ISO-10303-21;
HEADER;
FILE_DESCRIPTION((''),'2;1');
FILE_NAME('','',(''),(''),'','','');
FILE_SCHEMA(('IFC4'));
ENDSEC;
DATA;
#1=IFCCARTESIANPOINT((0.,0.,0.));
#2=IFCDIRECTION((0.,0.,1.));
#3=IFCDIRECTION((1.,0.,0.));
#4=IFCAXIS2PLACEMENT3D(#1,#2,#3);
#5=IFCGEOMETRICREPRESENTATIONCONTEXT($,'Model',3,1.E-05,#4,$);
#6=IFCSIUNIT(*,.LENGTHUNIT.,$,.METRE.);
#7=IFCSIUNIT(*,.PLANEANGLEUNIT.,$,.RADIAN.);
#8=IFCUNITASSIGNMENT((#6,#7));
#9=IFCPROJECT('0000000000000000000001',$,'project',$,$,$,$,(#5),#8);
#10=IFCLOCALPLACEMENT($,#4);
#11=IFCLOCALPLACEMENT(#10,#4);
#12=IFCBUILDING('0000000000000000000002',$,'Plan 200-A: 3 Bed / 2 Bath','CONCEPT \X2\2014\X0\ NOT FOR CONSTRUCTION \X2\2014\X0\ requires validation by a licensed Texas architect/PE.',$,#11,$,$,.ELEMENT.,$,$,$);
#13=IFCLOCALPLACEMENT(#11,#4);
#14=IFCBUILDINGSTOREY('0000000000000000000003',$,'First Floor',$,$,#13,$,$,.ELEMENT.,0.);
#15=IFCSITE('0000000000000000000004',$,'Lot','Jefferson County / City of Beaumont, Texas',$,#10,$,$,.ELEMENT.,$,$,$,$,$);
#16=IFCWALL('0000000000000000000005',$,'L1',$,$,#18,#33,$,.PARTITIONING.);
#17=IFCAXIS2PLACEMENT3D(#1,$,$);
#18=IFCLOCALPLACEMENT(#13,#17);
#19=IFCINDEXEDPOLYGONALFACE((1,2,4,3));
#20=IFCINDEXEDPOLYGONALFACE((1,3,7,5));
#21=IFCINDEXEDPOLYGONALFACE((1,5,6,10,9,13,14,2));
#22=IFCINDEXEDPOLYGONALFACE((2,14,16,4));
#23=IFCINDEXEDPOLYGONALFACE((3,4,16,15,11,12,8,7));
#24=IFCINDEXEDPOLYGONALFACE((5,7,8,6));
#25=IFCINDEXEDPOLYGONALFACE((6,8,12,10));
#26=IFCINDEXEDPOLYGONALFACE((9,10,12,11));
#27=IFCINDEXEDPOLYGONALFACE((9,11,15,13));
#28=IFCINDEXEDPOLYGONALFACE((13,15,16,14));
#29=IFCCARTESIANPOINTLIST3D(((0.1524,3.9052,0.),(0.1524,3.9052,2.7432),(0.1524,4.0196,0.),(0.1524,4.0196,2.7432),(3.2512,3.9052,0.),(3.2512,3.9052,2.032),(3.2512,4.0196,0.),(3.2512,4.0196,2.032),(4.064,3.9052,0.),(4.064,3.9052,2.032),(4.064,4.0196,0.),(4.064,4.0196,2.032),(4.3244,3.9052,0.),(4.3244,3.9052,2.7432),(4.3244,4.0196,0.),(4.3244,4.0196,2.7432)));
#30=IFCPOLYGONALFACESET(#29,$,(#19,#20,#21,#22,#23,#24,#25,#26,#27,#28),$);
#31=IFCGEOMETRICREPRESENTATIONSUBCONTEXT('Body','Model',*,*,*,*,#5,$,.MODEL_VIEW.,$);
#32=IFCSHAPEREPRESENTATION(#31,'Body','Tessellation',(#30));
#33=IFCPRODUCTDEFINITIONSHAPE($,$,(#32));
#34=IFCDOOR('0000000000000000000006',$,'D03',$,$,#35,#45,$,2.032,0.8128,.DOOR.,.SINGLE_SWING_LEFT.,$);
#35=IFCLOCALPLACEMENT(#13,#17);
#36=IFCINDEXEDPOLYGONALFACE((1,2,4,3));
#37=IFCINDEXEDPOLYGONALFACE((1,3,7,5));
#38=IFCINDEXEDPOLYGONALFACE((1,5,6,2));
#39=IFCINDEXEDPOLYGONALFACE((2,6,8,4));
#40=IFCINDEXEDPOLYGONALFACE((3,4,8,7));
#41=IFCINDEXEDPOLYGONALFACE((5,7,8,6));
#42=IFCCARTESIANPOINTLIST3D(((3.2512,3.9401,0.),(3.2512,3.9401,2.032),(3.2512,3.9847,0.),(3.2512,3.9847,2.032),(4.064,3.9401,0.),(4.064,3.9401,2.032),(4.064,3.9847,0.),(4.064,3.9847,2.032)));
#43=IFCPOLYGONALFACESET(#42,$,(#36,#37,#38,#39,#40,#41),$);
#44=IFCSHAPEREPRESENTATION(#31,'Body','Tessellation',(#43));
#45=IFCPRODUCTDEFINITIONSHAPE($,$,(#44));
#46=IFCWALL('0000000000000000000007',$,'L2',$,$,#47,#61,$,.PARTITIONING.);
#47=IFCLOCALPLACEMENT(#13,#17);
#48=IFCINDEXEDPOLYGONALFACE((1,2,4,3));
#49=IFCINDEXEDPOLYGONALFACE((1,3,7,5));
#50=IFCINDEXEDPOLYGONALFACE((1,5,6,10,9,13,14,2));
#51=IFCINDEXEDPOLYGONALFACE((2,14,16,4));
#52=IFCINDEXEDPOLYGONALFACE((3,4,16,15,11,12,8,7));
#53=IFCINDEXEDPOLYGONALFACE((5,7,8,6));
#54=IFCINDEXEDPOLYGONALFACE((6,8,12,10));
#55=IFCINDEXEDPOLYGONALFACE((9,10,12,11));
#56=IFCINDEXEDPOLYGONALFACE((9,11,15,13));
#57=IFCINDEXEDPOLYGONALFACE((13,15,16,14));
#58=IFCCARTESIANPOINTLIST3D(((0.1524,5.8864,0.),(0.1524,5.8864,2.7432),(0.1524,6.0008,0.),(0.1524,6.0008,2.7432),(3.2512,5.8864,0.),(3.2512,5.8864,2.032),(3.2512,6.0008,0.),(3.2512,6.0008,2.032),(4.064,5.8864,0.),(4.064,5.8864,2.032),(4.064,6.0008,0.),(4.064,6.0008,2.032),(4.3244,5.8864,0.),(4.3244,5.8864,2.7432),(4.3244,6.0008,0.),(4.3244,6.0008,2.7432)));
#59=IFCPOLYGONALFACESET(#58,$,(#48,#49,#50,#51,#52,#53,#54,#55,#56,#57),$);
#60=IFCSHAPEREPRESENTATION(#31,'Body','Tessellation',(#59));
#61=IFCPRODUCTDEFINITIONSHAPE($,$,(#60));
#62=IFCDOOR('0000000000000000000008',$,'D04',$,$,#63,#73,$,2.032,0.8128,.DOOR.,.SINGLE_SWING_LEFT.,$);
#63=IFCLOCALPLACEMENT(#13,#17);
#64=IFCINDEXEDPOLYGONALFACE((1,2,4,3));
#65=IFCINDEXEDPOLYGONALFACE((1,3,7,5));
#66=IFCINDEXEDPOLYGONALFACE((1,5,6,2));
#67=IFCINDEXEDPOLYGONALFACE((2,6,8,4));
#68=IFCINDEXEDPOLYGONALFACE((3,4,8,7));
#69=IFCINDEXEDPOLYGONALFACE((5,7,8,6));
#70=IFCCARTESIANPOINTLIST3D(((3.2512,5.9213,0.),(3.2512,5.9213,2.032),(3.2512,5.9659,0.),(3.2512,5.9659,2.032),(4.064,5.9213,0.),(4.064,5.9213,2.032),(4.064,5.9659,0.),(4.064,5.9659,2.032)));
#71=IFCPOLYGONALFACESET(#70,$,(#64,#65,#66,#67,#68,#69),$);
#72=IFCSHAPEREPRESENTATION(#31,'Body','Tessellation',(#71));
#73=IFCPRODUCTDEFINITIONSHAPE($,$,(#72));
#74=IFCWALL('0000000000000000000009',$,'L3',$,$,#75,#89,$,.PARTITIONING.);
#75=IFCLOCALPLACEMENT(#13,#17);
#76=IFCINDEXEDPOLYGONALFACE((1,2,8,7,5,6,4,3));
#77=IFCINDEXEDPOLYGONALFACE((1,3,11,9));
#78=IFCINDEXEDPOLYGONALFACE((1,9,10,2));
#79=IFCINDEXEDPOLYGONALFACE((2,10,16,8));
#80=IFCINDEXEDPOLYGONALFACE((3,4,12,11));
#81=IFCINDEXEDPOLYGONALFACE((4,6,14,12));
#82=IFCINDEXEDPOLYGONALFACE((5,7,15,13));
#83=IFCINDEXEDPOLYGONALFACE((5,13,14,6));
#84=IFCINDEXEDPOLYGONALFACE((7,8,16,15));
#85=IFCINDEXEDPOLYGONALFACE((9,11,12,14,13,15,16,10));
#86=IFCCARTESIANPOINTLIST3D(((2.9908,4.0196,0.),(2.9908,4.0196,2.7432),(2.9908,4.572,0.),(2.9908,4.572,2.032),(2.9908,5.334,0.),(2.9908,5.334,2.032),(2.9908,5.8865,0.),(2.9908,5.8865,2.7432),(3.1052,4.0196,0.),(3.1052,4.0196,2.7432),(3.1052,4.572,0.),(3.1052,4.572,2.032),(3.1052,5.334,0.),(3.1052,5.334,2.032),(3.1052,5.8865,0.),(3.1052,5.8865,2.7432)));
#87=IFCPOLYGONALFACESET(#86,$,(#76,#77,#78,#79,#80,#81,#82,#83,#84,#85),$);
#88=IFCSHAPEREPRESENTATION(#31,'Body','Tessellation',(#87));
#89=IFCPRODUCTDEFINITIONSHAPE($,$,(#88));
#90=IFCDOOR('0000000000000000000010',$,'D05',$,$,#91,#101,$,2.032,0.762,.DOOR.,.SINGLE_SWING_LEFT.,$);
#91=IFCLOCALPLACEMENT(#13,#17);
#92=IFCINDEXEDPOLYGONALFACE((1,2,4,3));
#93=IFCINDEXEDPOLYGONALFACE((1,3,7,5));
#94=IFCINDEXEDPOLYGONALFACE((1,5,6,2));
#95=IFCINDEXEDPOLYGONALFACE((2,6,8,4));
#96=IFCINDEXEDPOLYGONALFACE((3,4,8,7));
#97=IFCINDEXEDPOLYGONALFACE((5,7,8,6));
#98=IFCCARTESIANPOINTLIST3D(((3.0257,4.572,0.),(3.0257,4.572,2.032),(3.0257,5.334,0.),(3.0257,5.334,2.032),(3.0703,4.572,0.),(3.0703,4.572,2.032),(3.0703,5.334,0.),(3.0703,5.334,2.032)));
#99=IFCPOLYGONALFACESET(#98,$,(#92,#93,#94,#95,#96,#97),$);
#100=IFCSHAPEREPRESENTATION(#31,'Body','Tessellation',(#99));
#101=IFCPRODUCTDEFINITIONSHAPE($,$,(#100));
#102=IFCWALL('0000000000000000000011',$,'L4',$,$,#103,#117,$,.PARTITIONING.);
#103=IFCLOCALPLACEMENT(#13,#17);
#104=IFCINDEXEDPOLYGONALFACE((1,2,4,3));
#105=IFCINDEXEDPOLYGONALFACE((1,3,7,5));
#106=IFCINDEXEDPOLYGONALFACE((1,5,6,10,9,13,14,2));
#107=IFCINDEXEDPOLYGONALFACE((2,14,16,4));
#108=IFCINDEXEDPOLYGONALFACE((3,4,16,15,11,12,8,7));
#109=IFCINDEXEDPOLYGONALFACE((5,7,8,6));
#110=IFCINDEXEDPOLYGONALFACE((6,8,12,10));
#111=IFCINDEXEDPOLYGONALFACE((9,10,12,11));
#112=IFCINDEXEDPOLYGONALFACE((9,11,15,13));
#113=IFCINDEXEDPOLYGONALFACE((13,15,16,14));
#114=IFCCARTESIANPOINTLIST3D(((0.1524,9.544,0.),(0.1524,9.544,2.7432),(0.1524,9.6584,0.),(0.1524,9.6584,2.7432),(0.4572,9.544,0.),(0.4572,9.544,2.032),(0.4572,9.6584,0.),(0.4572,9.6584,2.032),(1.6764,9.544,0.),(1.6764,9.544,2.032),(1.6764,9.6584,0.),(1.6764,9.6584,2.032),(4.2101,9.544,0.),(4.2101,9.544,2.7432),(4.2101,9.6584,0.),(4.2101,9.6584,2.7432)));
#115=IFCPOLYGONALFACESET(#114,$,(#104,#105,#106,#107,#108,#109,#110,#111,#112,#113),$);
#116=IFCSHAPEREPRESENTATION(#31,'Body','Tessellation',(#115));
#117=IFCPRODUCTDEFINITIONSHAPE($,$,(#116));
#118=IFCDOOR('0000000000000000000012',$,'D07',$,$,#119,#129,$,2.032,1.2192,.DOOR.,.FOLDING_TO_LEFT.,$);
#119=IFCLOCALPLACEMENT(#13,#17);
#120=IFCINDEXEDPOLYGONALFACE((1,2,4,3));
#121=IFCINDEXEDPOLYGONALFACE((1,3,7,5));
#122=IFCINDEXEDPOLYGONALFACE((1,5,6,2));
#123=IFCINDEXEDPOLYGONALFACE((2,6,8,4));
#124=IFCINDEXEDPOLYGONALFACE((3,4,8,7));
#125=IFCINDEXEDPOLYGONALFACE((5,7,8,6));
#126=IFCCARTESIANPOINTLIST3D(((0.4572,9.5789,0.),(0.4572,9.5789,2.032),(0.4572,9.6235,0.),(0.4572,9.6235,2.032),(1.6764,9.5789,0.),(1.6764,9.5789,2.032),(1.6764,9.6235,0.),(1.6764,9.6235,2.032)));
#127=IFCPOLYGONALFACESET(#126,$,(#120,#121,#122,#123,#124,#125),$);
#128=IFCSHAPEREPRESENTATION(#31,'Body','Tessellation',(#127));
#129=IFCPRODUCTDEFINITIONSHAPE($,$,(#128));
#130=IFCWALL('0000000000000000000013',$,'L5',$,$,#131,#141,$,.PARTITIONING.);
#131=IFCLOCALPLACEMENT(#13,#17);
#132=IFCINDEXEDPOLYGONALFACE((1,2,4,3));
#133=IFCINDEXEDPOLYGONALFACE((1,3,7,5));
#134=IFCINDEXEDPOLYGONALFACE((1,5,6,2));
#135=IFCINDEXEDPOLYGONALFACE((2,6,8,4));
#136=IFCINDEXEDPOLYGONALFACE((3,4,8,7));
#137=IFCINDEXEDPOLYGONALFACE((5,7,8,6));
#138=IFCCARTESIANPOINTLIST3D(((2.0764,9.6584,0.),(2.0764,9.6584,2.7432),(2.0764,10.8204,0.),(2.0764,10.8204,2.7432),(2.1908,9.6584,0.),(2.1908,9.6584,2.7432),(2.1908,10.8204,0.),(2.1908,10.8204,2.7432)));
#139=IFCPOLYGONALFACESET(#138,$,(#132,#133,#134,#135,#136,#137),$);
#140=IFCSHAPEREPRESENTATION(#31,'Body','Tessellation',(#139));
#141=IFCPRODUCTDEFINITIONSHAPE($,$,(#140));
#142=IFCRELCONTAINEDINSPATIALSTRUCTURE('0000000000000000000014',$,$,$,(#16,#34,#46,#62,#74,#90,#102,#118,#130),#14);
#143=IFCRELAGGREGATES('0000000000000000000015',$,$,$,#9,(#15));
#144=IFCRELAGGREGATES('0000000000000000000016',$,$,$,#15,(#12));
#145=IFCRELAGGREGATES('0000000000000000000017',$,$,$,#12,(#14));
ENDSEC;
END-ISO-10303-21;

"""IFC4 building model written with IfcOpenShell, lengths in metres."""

from ifc_helpers import new_model, si_unit, frame, frame_2d, origin_with_axes, place, context, subcontext, project, spatial, rectangle, extrude, element, fill, save


model = new_model("IFC4")

# Units and contexts
model_context = context("Model", 3, precision=1e-05, world=origin_with_axes())
body_context = subcontext(model_context, "Body", "Model", "MODEL_VIEW")
ifc_project = project(units=[si_unit("LENGTHUNIT", "METRE"), si_unit("PLANEANGLEUNIT", "RADIAN")], contexts=[model_context])

# Site, building, storey
site_placement = place(None, origin_with_axes())
site = spatial("IfcSite", under=ifc_project, at=site_placement, Name="Lot", Description="Jefferson County / City of Beaumont, Texas", CompositionType="ELEMENT")
building_placement = place(site_placement, origin_with_axes())
building = spatial("IfcBuilding", under=site, at=building_placement, Name="Plan 200-A: 3 Bed / 2 Bath", Description="CONCEPT — NOT FOR CONSTRUCTION — requires validation by a licensed Texas architect/PE.", CompositionType="ELEMENT")
storey_placement = place(building_placement, origin_with_axes())
storey = spatial("IfcBuildingStorey", under=building, at=storey_placement, Name="First Floor", CompositionType="ELEMENT", Elevation=0.0)

# Walls, openings, doors
wall_1_placement = place(storey_placement, frame((0.1524, 3.9624, 0.0), z_axis=(0.0, 0.0, 1.0), x_axis=(1.0, 0.0, 0.0)))
wall_1 = element("IfcWall", 1, at=wall_1_placement, inside=storey, Name="L1", PredefinedType="PARTITIONING", context=body_context, shape_type="SweptSolid", body=[
    extrude(rectangle(XDim=4.1719, YDim=0.1143, at=frame_2d((2.086, 0.0), x_axis=(1.0, 0.0))), origin_with_axes(), (0.0, 0.0, 1.0), 2.7432),
])
opening_1_placement = place(wall_1_placement, frame((3.0988, 0.0, 0.0), z_axis=(0.0, 0.0, 1.0), x_axis=(1.0, 0.0, 0.0)))
opening_1 = element("IfcOpeningElement", 2, at=opening_1_placement, cuts=wall_1, PredefinedType="OPENING", context=body_context, shape_type="SweptSolid", body=[
    extrude(rectangle(XDim=0.8128, YDim=0.1448, at=frame_2d((0.4064, 0.0), x_axis=(1.0, 0.0))), origin_with_axes(), (0.0, 0.0, 1.0), 2.032),
])
door_1_placement = place(opening_1_placement, origin_with_axes())
door_1 = element("IfcDoor", 3, at=door_1_placement, inside=storey, Name="D03", OperationType="SINGLE_SWING_LEFT", OverallHeight=2.032, OverallWidth=0.8128, PredefinedType="DOOR", context=body_context, shape_type="SweptSolid", body=[
    extrude(rectangle(XDim=0.8128, YDim=0.0445, at=frame_2d((0.4064, 0.0), x_axis=(1.0, 0.0))), origin_with_axes(), (0.0, 0.0, 1.0), 2.032),
])
fill(opening_1, door_1)
wall_2_placement = place(storey_placement, frame((0.1524, 5.9436, 0.0), z_axis=(0.0, 0.0, 1.0), x_axis=(1.0, 0.0, 0.0)))
wall_2 = element("IfcWall", 4, at=wall_2_placement, inside=storey, Name="L2", PredefinedType="PARTITIONING", context=body_context, shape_type="SweptSolid", body=[
    extrude(rectangle(XDim=4.1719, YDim=0.1143, at=frame_2d((2.086, 0.0), x_axis=(1.0, 0.0))), origin_with_axes(), (0.0, 0.0, 1.0), 2.7432),
])
opening_2_placement = place(wall_2_placement, frame((3.0988, 0.0, 0.0), z_axis=(0.0, 0.0, 1.0), x_axis=(1.0, 0.0, 0.0)))
opening_2 = element("IfcOpeningElement", 5, at=opening_2_placement, cuts=wall_2, PredefinedType="OPENING", context=body_context, shape_type="SweptSolid", body=[
    extrude(rectangle(XDim=0.8128, YDim=0.1448, at=frame_2d((0.4064, 0.0), x_axis=(1.0, 0.0))), origin_with_axes(), (0.0, 0.0, 1.0), 2.032),
])
door_2_placement = place(opening_2_placement, origin_with_axes())
door_2 = element("IfcDoor", 6, at=door_2_placement, inside=storey, Name="D04", OperationType="SINGLE_SWING_LEFT", OverallHeight=2.032, OverallWidth=0.8128, PredefinedType="DOOR", context=body_context, shape_type="SweptSolid", body=[
    extrude(rectangle(XDim=0.8128, YDim=0.0445, at=frame_2d((0.4064, 0.0), x_axis=(1.0, 0.0))), origin_with_axes(), (0.0, 0.0, 1.0), 2.032),
])
fill(opening_2, door_2)
wall_3_placement = place(storey_placement, frame((3.048, 4.0196, 0.0), z_axis=(0.0, 0.0, 1.0), x_axis=(0.0, 1.0, 0.0)))
wall_3 = element("IfcWall", 7, at=wall_3_placement, inside=storey, Name="L3", PredefinedType="PARTITIONING", context=body_context, shape_type="SweptSolid", body=[
    extrude(rectangle(XDim=1.8669, YDim=0.1143, at=frame_2d((0.9335, 0.0), x_axis=(1.0, 0.0))), origin_with_axes(), (0.0, 0.0, 1.0), 2.7432),
])
opening_3_placement = place(wall_3_placement, frame((0.5524, 0.0, 0.0), z_axis=(0.0, 0.0, 1.0), x_axis=(1.0, 0.0, 0.0)))
opening_3 = element("IfcOpeningElement", 8, at=opening_3_placement, cuts=wall_3, PredefinedType="OPENING", context=body_context, shape_type="SweptSolid", body=[
    extrude(rectangle(XDim=0.762, YDim=0.1448, at=frame_2d((0.381, 0.0), x_axis=(1.0, 0.0))), origin_with_axes(), (0.0, 0.0, 1.0), 2.032),
])
door_3_placement = place(opening_3_placement, origin_with_axes())
door_3 = element("IfcDoor", 9, at=door_3_placement, inside=storey, Name="D05", OperationType="SINGLE_SWING_LEFT", OverallHeight=2.032, OverallWidth=0.762, PredefinedType="DOOR", context=body_context, shape_type="SweptSolid", body=[
    extrude(rectangle(XDim=0.762, YDim=0.0445, at=frame_2d((0.381, 0.0), x_axis=(1.0, 0.0))), origin_with_axes(), (0.0, 0.0, 1.0), 2.032),
])
fill(opening_3, door_3)
wall_4_placement = place(storey_placement, frame((0.1524, 9.6012, 0.0), z_axis=(0.0, 0.0, 1.0), x_axis=(1.0, 0.0, 0.0)))
wall_4 = element("IfcWall", 10, at=wall_4_placement, inside=storey, Name="L4", PredefinedType="PARTITIONING", context=body_context, shape_type="SweptSolid", body=[
    extrude(rectangle(XDim=4.0577, YDim=0.1143, at=frame_2d((2.0288, 0.0), x_axis=(1.0, 0.0))), origin_with_axes(), (0.0, 0.0, 1.0), 2.7432),
])
opening_4_placement = place(wall_4_placement, frame((0.3048, 0.0, 0.0), z_axis=(0.0, 0.0, 1.0), x_axis=(1.0, 0.0, 0.0)))
opening_4 = element("IfcOpeningElement", 11, at=opening_4_placement, cuts=wall_4, PredefinedType="OPENING", context=body_context, shape_type="SweptSolid", body=[
    extrude(rectangle(XDim=1.2192, YDim=0.1448, at=frame_2d((0.6096, 0.0), x_axis=(1.0, 0.0))), origin_with_axes(), (0.0, 0.0, 1.0), 2.032),
])
door_4_placement = place(opening_4_placement, origin_with_axes())
door_4 = element("IfcDoor", 12, at=door_4_placement, inside=storey, Name="D07", OperationType="FOLDING_TO_LEFT", OverallHeight=2.032, OverallWidth=1.2192, PredefinedType="DOOR", context=body_context, shape_type="SweptSolid", body=[
    extrude(rectangle(XDim=1.2192, YDim=0.0445, at=frame_2d((0.6096, 0.0), x_axis=(1.0, 0.0))), origin_with_axes(), (0.0, 0.0, 1.0), 2.032),
])
fill(opening_4, door_4)

# Wall
wall_5_placement = place(storey_placement, frame((2.1336, 9.6584, 0.0), z_axis=(0.0, 0.0, 1.0), x_axis=(0.0, 1.0, 0.0)))
element("IfcWall", 13, at=wall_5_placement, inside=storey, Name="L5", PredefinedType="PARTITIONING", context=body_context, shape_type="SweptSolid", body=[
    extrude(rectangle(XDim=1.1621, YDim=0.1143, at=frame_2d((0.581, 0.0), x_axis=(1.0, 0.0))), origin_with_axes(), (0.0, 0.0, 1.0), 2.7432),
])

save(model, "model.ifc")
